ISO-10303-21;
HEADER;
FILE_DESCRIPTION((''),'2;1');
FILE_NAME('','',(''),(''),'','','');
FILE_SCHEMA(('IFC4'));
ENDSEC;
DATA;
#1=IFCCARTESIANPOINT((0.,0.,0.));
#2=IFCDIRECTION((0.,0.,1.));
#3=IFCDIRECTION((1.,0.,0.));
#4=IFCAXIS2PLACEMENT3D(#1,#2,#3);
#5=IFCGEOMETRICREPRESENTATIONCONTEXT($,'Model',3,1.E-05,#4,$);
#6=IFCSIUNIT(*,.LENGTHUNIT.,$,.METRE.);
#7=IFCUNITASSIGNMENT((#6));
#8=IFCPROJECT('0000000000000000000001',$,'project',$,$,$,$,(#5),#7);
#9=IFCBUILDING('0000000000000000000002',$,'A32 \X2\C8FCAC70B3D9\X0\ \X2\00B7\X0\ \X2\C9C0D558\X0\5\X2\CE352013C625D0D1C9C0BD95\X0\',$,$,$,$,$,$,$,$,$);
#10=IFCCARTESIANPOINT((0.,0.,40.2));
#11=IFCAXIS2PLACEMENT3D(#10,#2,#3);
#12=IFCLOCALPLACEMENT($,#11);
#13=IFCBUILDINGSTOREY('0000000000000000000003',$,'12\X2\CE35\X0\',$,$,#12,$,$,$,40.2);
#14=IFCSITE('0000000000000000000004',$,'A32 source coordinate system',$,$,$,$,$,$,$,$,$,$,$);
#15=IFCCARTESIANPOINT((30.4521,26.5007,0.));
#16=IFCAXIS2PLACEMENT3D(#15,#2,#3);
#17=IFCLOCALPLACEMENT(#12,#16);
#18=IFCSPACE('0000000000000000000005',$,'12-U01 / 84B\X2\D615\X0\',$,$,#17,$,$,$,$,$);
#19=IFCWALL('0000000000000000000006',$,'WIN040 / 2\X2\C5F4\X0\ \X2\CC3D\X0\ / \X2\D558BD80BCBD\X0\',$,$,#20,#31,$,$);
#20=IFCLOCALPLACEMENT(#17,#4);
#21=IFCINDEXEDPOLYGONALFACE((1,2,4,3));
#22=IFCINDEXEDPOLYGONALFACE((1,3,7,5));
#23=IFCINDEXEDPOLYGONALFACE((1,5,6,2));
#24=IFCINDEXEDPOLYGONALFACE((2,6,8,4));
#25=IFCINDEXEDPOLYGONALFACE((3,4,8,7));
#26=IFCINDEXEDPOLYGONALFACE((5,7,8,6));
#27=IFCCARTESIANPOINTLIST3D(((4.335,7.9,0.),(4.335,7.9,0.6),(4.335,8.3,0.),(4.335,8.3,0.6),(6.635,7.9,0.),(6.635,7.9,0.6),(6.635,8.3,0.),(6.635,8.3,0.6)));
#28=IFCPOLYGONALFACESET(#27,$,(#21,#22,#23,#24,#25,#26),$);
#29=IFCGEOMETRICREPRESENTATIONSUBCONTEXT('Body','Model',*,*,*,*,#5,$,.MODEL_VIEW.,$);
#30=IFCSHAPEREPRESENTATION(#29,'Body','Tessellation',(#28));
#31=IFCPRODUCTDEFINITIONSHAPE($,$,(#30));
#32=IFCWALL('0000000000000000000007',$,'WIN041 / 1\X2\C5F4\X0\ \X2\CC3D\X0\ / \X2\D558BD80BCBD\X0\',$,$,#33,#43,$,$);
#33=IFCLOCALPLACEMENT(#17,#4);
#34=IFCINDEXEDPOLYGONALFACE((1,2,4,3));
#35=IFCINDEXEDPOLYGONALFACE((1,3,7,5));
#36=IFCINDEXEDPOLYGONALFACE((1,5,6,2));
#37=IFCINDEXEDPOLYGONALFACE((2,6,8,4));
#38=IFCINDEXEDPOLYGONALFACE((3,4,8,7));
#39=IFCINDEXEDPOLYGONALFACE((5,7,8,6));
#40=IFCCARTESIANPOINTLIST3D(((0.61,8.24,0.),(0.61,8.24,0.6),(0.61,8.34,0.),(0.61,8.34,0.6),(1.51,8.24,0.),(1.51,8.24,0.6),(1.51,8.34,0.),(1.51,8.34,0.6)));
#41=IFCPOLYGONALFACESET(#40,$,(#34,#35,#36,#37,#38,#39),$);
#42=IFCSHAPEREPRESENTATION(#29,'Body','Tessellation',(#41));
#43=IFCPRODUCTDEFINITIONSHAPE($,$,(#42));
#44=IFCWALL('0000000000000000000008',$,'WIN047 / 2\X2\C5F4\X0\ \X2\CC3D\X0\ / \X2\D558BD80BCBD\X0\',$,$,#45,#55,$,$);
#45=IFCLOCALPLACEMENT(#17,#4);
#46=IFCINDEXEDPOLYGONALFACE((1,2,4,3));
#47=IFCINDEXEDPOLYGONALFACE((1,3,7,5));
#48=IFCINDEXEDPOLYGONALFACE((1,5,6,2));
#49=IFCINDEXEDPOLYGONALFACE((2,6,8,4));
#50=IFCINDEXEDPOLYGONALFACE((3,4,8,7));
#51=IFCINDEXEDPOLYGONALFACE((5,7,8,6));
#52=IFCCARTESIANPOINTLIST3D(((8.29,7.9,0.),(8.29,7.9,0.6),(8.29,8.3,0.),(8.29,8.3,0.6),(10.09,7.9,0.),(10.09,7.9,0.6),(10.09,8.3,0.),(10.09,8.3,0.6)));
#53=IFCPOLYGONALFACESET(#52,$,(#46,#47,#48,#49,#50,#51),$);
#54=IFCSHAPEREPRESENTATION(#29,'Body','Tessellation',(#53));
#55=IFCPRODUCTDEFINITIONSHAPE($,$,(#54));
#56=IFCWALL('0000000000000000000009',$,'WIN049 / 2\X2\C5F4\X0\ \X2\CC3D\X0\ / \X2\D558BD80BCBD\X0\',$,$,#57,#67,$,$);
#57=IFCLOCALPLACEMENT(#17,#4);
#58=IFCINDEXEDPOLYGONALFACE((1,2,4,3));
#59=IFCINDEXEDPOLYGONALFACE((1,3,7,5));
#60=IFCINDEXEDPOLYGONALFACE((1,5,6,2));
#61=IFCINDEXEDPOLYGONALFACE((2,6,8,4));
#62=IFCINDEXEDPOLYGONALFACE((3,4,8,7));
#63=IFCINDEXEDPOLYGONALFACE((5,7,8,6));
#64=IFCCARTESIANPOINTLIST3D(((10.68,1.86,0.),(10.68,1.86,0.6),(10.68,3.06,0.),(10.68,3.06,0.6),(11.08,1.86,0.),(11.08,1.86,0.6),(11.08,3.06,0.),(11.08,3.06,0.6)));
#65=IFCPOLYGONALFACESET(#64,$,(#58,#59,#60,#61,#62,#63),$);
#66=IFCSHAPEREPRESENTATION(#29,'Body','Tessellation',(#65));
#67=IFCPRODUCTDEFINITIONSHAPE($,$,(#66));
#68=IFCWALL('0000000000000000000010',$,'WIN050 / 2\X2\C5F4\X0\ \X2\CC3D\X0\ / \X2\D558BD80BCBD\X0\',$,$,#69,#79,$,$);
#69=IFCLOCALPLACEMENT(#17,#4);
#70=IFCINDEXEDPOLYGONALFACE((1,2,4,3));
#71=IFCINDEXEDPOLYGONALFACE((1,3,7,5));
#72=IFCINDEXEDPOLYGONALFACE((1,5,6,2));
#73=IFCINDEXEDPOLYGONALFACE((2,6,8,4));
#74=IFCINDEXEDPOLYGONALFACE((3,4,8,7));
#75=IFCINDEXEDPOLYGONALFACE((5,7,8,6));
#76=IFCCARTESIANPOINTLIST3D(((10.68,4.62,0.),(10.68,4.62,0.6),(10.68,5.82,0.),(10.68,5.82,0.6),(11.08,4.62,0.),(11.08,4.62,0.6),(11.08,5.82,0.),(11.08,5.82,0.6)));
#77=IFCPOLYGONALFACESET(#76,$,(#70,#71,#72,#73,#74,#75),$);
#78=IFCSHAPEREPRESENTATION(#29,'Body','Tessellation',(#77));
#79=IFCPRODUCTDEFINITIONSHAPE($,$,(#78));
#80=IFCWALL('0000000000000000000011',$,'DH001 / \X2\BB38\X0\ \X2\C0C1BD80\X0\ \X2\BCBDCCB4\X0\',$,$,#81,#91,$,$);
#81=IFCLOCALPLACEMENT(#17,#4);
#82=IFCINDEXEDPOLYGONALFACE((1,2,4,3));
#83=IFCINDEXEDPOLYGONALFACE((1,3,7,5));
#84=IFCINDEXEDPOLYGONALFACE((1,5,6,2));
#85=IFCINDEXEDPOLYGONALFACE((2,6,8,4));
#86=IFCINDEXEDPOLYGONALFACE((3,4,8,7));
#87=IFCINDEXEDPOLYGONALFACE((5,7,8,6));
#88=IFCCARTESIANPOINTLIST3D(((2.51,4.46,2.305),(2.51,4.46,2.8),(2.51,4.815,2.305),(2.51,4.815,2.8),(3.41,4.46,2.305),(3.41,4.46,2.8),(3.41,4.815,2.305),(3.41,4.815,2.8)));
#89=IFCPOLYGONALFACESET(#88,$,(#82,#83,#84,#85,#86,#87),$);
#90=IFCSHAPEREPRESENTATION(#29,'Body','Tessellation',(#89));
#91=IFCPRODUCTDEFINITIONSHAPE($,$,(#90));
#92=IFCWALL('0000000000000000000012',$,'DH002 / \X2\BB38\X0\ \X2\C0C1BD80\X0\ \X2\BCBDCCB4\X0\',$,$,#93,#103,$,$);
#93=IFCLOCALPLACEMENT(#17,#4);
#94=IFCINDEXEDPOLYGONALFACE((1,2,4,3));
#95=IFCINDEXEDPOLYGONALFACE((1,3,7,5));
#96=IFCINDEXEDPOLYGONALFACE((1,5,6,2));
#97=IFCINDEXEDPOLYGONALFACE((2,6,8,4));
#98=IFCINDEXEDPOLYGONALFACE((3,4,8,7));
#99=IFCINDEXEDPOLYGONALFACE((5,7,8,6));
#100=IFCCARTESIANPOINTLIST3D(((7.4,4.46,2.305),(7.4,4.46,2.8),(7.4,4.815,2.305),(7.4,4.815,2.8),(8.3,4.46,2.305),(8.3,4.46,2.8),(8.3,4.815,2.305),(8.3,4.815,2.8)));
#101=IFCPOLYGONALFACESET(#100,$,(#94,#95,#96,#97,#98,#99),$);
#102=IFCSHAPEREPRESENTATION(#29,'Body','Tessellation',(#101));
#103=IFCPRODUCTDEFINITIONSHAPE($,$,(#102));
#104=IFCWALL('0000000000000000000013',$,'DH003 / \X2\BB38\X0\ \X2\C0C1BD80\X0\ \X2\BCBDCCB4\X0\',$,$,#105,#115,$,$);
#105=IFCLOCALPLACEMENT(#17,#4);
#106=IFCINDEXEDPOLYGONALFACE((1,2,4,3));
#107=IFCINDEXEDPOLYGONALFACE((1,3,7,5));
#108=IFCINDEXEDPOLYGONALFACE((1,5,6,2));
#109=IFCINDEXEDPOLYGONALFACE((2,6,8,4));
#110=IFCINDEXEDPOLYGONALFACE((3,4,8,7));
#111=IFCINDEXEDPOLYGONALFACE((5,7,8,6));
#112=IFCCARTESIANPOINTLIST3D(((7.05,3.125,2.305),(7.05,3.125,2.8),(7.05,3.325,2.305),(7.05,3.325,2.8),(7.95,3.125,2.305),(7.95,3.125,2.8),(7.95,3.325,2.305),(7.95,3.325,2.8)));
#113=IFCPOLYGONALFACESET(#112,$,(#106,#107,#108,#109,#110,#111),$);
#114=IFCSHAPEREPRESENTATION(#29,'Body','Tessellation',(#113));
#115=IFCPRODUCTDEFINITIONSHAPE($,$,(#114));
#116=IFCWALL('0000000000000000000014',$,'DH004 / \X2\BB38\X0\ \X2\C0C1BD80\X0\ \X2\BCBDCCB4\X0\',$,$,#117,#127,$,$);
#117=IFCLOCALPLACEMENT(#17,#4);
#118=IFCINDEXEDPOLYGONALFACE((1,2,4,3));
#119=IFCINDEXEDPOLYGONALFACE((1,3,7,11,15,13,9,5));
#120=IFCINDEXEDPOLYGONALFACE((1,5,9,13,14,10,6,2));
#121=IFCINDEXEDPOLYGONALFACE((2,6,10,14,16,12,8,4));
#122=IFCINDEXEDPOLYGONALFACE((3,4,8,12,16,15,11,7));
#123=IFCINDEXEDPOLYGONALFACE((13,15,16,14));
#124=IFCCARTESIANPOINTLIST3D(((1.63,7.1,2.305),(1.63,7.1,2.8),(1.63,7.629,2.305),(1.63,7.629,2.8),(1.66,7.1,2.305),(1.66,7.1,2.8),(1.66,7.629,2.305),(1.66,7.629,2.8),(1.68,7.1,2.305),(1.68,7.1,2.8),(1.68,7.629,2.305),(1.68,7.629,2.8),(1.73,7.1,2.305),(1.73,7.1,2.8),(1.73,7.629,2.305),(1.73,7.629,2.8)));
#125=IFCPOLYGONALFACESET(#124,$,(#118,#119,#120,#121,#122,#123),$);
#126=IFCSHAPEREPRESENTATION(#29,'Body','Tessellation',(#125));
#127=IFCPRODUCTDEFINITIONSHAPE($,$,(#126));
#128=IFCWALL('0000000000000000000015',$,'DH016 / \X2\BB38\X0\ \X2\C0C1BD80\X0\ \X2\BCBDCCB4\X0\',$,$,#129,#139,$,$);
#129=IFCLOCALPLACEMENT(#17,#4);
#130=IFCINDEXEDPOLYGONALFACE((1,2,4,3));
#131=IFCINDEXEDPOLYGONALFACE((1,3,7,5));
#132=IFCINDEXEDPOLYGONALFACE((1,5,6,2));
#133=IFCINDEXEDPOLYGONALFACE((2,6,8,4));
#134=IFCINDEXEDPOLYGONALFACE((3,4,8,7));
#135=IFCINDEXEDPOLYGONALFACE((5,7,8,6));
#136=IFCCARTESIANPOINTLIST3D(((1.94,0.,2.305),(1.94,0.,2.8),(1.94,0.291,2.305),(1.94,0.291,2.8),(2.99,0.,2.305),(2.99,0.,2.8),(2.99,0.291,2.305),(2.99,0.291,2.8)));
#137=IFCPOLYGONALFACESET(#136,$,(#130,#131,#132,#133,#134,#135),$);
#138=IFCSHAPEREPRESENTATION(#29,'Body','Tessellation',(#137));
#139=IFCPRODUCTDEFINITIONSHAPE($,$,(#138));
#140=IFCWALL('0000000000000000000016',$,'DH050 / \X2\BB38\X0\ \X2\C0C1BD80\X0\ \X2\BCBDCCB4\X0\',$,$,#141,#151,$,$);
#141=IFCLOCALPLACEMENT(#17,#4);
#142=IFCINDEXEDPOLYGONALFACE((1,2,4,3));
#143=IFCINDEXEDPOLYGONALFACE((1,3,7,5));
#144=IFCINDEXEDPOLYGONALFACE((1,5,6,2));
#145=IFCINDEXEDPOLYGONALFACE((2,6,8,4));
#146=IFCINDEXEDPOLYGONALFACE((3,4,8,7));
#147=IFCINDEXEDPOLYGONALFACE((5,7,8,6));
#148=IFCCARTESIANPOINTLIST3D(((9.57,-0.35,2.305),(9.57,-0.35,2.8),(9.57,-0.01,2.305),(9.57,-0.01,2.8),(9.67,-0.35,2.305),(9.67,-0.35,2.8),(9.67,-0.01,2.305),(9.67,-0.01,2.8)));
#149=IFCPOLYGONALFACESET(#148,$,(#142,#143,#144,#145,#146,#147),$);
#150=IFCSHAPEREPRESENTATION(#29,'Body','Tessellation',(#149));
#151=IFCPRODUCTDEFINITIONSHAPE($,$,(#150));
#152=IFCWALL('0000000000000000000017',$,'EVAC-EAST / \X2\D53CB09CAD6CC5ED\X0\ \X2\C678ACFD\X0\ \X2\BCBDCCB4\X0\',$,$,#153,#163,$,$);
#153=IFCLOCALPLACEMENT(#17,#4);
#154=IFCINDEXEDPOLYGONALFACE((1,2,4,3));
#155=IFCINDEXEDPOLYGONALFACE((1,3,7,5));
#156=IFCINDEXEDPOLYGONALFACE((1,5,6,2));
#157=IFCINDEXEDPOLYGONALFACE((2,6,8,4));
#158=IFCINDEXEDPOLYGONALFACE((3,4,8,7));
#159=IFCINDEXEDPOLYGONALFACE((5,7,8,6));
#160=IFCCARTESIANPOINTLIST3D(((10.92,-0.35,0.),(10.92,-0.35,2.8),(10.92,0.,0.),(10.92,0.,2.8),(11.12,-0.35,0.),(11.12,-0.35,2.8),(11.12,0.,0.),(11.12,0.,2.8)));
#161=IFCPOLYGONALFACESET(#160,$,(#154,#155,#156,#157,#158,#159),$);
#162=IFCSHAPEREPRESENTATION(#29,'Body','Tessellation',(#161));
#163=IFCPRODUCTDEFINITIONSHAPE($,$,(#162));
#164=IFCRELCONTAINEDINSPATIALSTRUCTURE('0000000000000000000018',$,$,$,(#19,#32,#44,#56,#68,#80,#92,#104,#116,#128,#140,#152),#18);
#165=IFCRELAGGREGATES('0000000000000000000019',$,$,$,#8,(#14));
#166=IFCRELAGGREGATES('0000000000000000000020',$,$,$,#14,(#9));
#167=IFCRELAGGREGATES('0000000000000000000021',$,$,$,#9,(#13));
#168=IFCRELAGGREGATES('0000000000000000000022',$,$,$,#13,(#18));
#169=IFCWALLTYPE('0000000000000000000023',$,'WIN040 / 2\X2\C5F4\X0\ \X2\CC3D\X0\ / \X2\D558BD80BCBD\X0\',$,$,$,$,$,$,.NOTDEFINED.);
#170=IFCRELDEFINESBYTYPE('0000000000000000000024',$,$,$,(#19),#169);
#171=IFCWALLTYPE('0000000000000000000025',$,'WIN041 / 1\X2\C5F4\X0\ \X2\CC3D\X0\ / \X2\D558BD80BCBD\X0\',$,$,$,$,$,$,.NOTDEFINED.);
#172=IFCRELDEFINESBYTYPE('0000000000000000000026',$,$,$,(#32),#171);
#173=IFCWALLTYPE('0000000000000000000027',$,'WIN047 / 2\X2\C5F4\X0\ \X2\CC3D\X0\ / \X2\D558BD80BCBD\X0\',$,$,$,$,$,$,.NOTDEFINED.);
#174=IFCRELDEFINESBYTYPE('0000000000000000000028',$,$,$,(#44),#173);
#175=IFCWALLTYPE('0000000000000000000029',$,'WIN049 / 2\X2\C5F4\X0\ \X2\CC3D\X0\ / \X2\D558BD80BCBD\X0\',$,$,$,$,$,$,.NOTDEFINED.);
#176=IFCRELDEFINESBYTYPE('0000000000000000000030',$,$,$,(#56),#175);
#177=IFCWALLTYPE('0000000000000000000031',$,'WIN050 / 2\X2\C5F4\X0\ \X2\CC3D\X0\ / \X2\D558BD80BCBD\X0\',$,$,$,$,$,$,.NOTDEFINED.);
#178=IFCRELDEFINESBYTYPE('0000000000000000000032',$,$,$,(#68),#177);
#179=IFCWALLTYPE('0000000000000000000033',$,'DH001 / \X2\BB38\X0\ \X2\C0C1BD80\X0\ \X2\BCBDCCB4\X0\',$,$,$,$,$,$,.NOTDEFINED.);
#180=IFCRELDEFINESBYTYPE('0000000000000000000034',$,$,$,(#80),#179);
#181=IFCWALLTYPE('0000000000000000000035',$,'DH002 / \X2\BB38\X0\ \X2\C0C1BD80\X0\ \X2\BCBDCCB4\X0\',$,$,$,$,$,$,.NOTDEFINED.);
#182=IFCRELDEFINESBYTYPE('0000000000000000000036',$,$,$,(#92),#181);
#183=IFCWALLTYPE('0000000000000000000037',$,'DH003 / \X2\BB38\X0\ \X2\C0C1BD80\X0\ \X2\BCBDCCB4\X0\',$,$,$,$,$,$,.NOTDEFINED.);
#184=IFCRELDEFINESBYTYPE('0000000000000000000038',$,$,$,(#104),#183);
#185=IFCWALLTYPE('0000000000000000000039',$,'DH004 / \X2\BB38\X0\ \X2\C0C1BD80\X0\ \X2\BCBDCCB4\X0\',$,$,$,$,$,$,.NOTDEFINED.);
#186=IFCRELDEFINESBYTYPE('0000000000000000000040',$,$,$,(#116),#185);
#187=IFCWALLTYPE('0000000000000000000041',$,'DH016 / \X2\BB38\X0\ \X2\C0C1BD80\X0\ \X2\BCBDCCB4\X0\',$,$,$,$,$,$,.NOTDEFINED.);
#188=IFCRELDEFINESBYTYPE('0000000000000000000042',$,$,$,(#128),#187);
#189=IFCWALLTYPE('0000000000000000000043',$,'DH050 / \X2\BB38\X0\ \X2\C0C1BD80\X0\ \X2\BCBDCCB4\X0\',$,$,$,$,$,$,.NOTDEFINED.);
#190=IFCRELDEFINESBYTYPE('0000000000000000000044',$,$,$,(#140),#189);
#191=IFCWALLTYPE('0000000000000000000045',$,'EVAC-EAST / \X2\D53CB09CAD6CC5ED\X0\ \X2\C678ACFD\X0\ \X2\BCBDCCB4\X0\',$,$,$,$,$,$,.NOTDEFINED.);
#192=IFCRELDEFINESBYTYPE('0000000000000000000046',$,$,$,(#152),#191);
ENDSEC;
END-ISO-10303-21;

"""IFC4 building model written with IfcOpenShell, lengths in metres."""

from ifc_helpers import new_model, si_unit, frame, origin, origin_with_axes, place, context, subcontext, project, spatial, polyline, outline, extrude, source, transform, mapped, type_object, type_shapes, element, save


model = new_model("IFC4")

# Units and contexts
model_context = context("Model", 3, precision=1e-05, world=origin_with_axes())
body_context = subcontext(model_context, "Body", "Model", "MODEL_VIEW")
ifc_project = project(units=[si_unit("LENGTHUNIT", "METRE")], contexts=[model_context])

# Site, building, storey, space
site = spatial("IfcSite", under=ifc_project, Name="A32 source coordinate system")
building = spatial("IfcBuilding", under=site, Name="A32 주거동 · 지하5층–옥탑지붕")
storey_placement = place(None, frame((0.0, 0.0, 40.2), z_axis=(0.0, 0.0, 1.0), x_axis=(1.0, 0.0, 0.0)))
storey = spatial("IfcBuildingStorey", under=building, at=storey_placement, Name="12층", Elevation=40.2)
space_placement = place(storey_placement, frame((30.4521, 26.5007, 0.0), z_axis=(0.0, 0.0, 1.0), x_axis=(1.0, 0.0, 0.0)))
space = spatial("IfcSpace", under=storey, at=space_placement, Name="12-U01 / 84B형")

# Walls
wall_type_1 = type_object("IfcWallType", Name="WIN040 / 2열 창 / 하부벽", PredefinedType="NOTDEFINED")
shared_shape_1 = source(origin(), body_context, "Body", "SweptSolid", [
    extrude(outline(polyline([(4.335, 8.3), (6.635, 8.3), (6.635, 7.9), (4.335, 7.9), (4.335, 8.3)])), origin(), (0.0, 0.0, 1.0), 0.6),
])
type_shapes(wall_type_1, [shared_shape_1])
wall_1_placement = place(space_placement, origin_with_axes())
element("IfcWall", 1, at=wall_1_placement, inside=space, type_object=wall_type_1, Name="WIN040 / 2열 창 / 하부벽", context=body_context, shape_type="MappedRepresentation", body=[
    mapped(shared_shape_1, transform((0.0, 0.0, 0.0), scale=1.0)),
])
wall_type_2 = type_object("IfcWallType", Name="WIN041 / 1열 창 / 하부벽", PredefinedType="NOTDEFINED")
shared_shape_2 = source(origin(), body_context, "Body", "SweptSolid", [
    extrude(outline(polyline([(0.61, 8.34), (1.51, 8.34), (1.51, 8.24), (0.61, 8.24), (0.61, 8.34)])), origin(), (0.0, 0.0, 1.0), 0.6),
])
type_shapes(wall_type_2, [shared_shape_2])
wall_2_placement = place(space_placement, origin_with_axes())
element("IfcWall", 2, at=wall_2_placement, inside=space, type_object=wall_type_2, Name="WIN041 / 1열 창 / 하부벽", context=body_context, shape_type="MappedRepresentation", body=[
    mapped(shared_shape_2, transform((0.0, 0.0, 0.0), scale=1.0)),
])
wall_type_3 = type_object("IfcWallType", Name="WIN047 / 2열 창 / 하부벽", PredefinedType="NOTDEFINED")
shared_shape_3 = source(origin(), body_context, "Body", "SweptSolid", [
    extrude(outline(polyline([(8.29, 8.3), (10.09, 8.3), (10.09, 7.9), (8.29, 7.9), (8.29, 8.3)])), origin(), (0.0, 0.0, 1.0), 0.6),
])
type_shapes(wall_type_3, [shared_shape_3])
wall_3_placement = place(space_placement, origin_with_axes())
element("IfcWall", 3, at=wall_3_placement, inside=space, type_object=wall_type_3, Name="WIN047 / 2열 창 / 하부벽", context=body_context, shape_type="MappedRepresentation", body=[
    mapped(shared_shape_3, transform((0.0, 0.0, 0.0), scale=1.0)),
])
wall_type_4 = type_object("IfcWallType", Name="WIN049 / 2열 창 / 하부벽", PredefinedType="NOTDEFINED")
shared_shape_4 = source(origin(), body_context, "Body", "SweptSolid", [
    extrude(outline(polyline([(10.68, 3.06), (11.08, 3.06), (11.08, 1.86), (10.68, 1.86), (10.68, 3.06)])), origin(), (0.0, 0.0, 1.0), 0.6),
])
type_shapes(wall_type_4, [shared_shape_4])
wall_4_placement = place(space_placement, origin_with_axes())
element("IfcWall", 4, at=wall_4_placement, inside=space, type_object=wall_type_4, Name="WIN049 / 2열 창 / 하부벽", context=body_context, shape_type="MappedRepresentation", body=[
    mapped(shared_shape_4, transform((0.0, 0.0, 0.0), scale=1.0)),
])
wall_type_5 = type_object("IfcWallType", Name="WIN050 / 2열 창 / 하부벽", PredefinedType="NOTDEFINED")
shared_shape_5 = source(origin(), body_context, "Body", "SweptSolid", [
    extrude(outline(polyline([(10.68, 5.82), (11.08, 5.82), (11.08, 4.62), (10.68, 4.62), (10.68, 5.82)])), origin(), (0.0, 0.0, 1.0), 0.6),
])
type_shapes(wall_type_5, [shared_shape_5])
wall_5_placement = place(space_placement, origin_with_axes())
element("IfcWall", 5, at=wall_5_placement, inside=space, type_object=wall_type_5, Name="WIN050 / 2열 창 / 하부벽", context=body_context, shape_type="MappedRepresentation", body=[
    mapped(shared_shape_5, transform((0.0, 0.0, 0.0), scale=1.0)),
])
wall_type_6 = type_object("IfcWallType", Name="DH001 / 문 상부 벽체", PredefinedType="NOTDEFINED")
shared_shape_6 = source(origin(), body_context, "Body", "SweptSolid", [
    extrude(outline(polyline([(3.41, 4.815), (3.41, 4.46), (2.51, 4.46), (2.51, 4.815), (3.41, 4.815)])), frame((0.0, 0.0, 2.305)), (0.0, 0.0, 1.0), 0.495),
])
type_shapes(wall_type_6, [shared_shape_6])
wall_6_placement = place(space_placement, origin_with_axes())
element("IfcWall", 6, at=wall_6_placement, inside=space, type_object=wall_type_6, Name="DH001 / 문 상부 벽체", context=body_context, shape_type="MappedRepresentation", body=[
    mapped(shared_shape_6, transform((0.0, 0.0, 0.0), scale=1.0)),
])
wall_type_7 = type_object("IfcWallType", Name="DH002 / 문 상부 벽체", PredefinedType="NOTDEFINED")
shared_shape_7 = source(origin(), body_context, "Body", "SweptSolid", [
    extrude(outline(polyline([(8.3, 4.815), (8.3, 4.46), (7.4, 4.46), (7.4, 4.815), (8.3, 4.815)])), frame((0.0, 0.0, 2.305)), (0.0, 0.0, 1.0), 0.495),
])
type_shapes(wall_type_7, [shared_shape_7])
wall_7_placement = place(space_placement, origin_with_axes())
element("IfcWall", 7, at=wall_7_placement, inside=space, type_object=wall_type_7, Name="DH002 / 문 상부 벽체", context=body_context, shape_type="MappedRepresentation", body=[
    mapped(shared_shape_7, transform((0.0, 0.0, 0.0), scale=1.0)),
])
wall_type_8 = type_object("IfcWallType", Name="DH003 / 문 상부 벽체", PredefinedType="NOTDEFINED")
shared_shape_8 = source(origin(), body_context, "Body", "SweptSolid", [
    extrude(outline(polyline([(7.95, 3.325), (7.95, 3.125), (7.05, 3.125), (7.05, 3.325), (7.95, 3.325)])), frame((0.0, 0.0, 2.305)), (0.0, 0.0, 1.0), 0.495),
])
type_shapes(wall_type_8, [shared_shape_8])
wall_8_placement = place(space_placement, origin_with_axes())
element("IfcWall", 8, at=wall_8_placement, inside=space, type_object=wall_type_8, Name="DH003 / 문 상부 벽체", context=body_context, shape_type="MappedRepresentation", body=[
    mapped(shared_shape_8, transform((0.0, 0.0, 0.0), scale=1.0)),
])
wall_type_9 = type_object("IfcWallType", Name="DH004 / 문 상부 벽체", PredefinedType="NOTDEFINED")
shared_shape_9 = source(origin(), body_context, "Body", "SweptSolid", [
    extrude(outline(polyline([(1.66, 7.1), (1.63, 7.1), (1.63, 7.629), (1.66, 7.629), (1.68, 7.629), (1.73, 7.629), (1.73, 7.1), (1.68, 7.1), (1.66, 7.1)])), frame((0.0, 0.0, 2.305)), (0.0, 0.0, 1.0), 0.495),
])
type_shapes(wall_type_9, [shared_shape_9])
wall_9_placement = place(space_placement, origin_with_axes())
element("IfcWall", 9, at=wall_9_placement, inside=space, type_object=wall_type_9, Name="DH004 / 문 상부 벽체", context=body_context, shape_type="MappedRepresentation", body=[
    mapped(shared_shape_9, transform((0.0, 0.0, 0.0), scale=1.0)),
])
wall_type_10 = type_object("IfcWallType", Name="DH016 / 문 상부 벽체", PredefinedType="NOTDEFINED")
shared_shape_10 = source(origin(), body_context, "Body", "SweptSolid", [
    extrude(outline(polyline([(2.99, 0.291), (2.99, 0.0), (1.94, 0.0), (1.94, 0.291), (2.99, 0.291)])), frame((0.0, 0.0, 2.305)), (0.0, 0.0, 1.0), 0.495),
])
type_shapes(wall_type_10, [shared_shape_10])
wall_10_placement = place(space_placement, origin_with_axes())
element("IfcWall", 10, at=wall_10_placement, inside=space, type_object=wall_type_10, Name="DH016 / 문 상부 벽체", context=body_context, shape_type="MappedRepresentation", body=[
    mapped(shared_shape_10, transform((0.0, 0.0, 0.0), scale=1.0)),
])
wall_type_11 = type_object("IfcWallType", Name="DH050 / 문 상부 벽체", PredefinedType="NOTDEFINED")
shared_shape_11 = source(origin(), body_context, "Body", "SweptSolid", [
    extrude(outline(polyline([(9.67, -0.01), (9.67, -0.35), (9.57, -0.35), (9.57, -0.01), (9.67, -0.01)])), frame((0.0, 0.0, 2.305)), (0.0, 0.0, 1.0), 0.495),
])
type_shapes(wall_type_11, [shared_shape_11])
wall_11_placement = place(space_placement, origin_with_axes())
element("IfcWall", 11, at=wall_11_placement, inside=space, type_object=wall_type_11, Name="DH050 / 문 상부 벽체", context=body_context, shape_type="MappedRepresentation", body=[
    mapped(shared_shape_11, transform((0.0, 0.0, 0.0), scale=1.0)),
])
wall_type_12 = type_object("IfcWallType", Name="EVAC-EAST / 피난구역 외곽 벽체", PredefinedType="NOTDEFINED")
shared_shape_12 = source(origin(), body_context, "Body", "SweptSolid", [
    extrude(outline(polyline([(10.92, 0.0), (11.12, 0.0), (11.12, -0.35), (10.92, -0.35), (10.92, 0.0)])), origin(), (0.0, 0.0, 1.0), 2.8),
])
type_shapes(wall_type_12, [shared_shape_12])
wall_12_placement = place(space_placement, origin_with_axes())
element("IfcWall", 12, at=wall_12_placement, inside=space, type_object=wall_type_12, Name="EVAC-EAST / 피난구역 외곽 벽체", context=body_context, shape_type="MappedRepresentation", body=[
    mapped(shared_shape_12, transform((0.0, 0.0, 0.0), scale=1.0)),
])

save(model, "model.ifc")
